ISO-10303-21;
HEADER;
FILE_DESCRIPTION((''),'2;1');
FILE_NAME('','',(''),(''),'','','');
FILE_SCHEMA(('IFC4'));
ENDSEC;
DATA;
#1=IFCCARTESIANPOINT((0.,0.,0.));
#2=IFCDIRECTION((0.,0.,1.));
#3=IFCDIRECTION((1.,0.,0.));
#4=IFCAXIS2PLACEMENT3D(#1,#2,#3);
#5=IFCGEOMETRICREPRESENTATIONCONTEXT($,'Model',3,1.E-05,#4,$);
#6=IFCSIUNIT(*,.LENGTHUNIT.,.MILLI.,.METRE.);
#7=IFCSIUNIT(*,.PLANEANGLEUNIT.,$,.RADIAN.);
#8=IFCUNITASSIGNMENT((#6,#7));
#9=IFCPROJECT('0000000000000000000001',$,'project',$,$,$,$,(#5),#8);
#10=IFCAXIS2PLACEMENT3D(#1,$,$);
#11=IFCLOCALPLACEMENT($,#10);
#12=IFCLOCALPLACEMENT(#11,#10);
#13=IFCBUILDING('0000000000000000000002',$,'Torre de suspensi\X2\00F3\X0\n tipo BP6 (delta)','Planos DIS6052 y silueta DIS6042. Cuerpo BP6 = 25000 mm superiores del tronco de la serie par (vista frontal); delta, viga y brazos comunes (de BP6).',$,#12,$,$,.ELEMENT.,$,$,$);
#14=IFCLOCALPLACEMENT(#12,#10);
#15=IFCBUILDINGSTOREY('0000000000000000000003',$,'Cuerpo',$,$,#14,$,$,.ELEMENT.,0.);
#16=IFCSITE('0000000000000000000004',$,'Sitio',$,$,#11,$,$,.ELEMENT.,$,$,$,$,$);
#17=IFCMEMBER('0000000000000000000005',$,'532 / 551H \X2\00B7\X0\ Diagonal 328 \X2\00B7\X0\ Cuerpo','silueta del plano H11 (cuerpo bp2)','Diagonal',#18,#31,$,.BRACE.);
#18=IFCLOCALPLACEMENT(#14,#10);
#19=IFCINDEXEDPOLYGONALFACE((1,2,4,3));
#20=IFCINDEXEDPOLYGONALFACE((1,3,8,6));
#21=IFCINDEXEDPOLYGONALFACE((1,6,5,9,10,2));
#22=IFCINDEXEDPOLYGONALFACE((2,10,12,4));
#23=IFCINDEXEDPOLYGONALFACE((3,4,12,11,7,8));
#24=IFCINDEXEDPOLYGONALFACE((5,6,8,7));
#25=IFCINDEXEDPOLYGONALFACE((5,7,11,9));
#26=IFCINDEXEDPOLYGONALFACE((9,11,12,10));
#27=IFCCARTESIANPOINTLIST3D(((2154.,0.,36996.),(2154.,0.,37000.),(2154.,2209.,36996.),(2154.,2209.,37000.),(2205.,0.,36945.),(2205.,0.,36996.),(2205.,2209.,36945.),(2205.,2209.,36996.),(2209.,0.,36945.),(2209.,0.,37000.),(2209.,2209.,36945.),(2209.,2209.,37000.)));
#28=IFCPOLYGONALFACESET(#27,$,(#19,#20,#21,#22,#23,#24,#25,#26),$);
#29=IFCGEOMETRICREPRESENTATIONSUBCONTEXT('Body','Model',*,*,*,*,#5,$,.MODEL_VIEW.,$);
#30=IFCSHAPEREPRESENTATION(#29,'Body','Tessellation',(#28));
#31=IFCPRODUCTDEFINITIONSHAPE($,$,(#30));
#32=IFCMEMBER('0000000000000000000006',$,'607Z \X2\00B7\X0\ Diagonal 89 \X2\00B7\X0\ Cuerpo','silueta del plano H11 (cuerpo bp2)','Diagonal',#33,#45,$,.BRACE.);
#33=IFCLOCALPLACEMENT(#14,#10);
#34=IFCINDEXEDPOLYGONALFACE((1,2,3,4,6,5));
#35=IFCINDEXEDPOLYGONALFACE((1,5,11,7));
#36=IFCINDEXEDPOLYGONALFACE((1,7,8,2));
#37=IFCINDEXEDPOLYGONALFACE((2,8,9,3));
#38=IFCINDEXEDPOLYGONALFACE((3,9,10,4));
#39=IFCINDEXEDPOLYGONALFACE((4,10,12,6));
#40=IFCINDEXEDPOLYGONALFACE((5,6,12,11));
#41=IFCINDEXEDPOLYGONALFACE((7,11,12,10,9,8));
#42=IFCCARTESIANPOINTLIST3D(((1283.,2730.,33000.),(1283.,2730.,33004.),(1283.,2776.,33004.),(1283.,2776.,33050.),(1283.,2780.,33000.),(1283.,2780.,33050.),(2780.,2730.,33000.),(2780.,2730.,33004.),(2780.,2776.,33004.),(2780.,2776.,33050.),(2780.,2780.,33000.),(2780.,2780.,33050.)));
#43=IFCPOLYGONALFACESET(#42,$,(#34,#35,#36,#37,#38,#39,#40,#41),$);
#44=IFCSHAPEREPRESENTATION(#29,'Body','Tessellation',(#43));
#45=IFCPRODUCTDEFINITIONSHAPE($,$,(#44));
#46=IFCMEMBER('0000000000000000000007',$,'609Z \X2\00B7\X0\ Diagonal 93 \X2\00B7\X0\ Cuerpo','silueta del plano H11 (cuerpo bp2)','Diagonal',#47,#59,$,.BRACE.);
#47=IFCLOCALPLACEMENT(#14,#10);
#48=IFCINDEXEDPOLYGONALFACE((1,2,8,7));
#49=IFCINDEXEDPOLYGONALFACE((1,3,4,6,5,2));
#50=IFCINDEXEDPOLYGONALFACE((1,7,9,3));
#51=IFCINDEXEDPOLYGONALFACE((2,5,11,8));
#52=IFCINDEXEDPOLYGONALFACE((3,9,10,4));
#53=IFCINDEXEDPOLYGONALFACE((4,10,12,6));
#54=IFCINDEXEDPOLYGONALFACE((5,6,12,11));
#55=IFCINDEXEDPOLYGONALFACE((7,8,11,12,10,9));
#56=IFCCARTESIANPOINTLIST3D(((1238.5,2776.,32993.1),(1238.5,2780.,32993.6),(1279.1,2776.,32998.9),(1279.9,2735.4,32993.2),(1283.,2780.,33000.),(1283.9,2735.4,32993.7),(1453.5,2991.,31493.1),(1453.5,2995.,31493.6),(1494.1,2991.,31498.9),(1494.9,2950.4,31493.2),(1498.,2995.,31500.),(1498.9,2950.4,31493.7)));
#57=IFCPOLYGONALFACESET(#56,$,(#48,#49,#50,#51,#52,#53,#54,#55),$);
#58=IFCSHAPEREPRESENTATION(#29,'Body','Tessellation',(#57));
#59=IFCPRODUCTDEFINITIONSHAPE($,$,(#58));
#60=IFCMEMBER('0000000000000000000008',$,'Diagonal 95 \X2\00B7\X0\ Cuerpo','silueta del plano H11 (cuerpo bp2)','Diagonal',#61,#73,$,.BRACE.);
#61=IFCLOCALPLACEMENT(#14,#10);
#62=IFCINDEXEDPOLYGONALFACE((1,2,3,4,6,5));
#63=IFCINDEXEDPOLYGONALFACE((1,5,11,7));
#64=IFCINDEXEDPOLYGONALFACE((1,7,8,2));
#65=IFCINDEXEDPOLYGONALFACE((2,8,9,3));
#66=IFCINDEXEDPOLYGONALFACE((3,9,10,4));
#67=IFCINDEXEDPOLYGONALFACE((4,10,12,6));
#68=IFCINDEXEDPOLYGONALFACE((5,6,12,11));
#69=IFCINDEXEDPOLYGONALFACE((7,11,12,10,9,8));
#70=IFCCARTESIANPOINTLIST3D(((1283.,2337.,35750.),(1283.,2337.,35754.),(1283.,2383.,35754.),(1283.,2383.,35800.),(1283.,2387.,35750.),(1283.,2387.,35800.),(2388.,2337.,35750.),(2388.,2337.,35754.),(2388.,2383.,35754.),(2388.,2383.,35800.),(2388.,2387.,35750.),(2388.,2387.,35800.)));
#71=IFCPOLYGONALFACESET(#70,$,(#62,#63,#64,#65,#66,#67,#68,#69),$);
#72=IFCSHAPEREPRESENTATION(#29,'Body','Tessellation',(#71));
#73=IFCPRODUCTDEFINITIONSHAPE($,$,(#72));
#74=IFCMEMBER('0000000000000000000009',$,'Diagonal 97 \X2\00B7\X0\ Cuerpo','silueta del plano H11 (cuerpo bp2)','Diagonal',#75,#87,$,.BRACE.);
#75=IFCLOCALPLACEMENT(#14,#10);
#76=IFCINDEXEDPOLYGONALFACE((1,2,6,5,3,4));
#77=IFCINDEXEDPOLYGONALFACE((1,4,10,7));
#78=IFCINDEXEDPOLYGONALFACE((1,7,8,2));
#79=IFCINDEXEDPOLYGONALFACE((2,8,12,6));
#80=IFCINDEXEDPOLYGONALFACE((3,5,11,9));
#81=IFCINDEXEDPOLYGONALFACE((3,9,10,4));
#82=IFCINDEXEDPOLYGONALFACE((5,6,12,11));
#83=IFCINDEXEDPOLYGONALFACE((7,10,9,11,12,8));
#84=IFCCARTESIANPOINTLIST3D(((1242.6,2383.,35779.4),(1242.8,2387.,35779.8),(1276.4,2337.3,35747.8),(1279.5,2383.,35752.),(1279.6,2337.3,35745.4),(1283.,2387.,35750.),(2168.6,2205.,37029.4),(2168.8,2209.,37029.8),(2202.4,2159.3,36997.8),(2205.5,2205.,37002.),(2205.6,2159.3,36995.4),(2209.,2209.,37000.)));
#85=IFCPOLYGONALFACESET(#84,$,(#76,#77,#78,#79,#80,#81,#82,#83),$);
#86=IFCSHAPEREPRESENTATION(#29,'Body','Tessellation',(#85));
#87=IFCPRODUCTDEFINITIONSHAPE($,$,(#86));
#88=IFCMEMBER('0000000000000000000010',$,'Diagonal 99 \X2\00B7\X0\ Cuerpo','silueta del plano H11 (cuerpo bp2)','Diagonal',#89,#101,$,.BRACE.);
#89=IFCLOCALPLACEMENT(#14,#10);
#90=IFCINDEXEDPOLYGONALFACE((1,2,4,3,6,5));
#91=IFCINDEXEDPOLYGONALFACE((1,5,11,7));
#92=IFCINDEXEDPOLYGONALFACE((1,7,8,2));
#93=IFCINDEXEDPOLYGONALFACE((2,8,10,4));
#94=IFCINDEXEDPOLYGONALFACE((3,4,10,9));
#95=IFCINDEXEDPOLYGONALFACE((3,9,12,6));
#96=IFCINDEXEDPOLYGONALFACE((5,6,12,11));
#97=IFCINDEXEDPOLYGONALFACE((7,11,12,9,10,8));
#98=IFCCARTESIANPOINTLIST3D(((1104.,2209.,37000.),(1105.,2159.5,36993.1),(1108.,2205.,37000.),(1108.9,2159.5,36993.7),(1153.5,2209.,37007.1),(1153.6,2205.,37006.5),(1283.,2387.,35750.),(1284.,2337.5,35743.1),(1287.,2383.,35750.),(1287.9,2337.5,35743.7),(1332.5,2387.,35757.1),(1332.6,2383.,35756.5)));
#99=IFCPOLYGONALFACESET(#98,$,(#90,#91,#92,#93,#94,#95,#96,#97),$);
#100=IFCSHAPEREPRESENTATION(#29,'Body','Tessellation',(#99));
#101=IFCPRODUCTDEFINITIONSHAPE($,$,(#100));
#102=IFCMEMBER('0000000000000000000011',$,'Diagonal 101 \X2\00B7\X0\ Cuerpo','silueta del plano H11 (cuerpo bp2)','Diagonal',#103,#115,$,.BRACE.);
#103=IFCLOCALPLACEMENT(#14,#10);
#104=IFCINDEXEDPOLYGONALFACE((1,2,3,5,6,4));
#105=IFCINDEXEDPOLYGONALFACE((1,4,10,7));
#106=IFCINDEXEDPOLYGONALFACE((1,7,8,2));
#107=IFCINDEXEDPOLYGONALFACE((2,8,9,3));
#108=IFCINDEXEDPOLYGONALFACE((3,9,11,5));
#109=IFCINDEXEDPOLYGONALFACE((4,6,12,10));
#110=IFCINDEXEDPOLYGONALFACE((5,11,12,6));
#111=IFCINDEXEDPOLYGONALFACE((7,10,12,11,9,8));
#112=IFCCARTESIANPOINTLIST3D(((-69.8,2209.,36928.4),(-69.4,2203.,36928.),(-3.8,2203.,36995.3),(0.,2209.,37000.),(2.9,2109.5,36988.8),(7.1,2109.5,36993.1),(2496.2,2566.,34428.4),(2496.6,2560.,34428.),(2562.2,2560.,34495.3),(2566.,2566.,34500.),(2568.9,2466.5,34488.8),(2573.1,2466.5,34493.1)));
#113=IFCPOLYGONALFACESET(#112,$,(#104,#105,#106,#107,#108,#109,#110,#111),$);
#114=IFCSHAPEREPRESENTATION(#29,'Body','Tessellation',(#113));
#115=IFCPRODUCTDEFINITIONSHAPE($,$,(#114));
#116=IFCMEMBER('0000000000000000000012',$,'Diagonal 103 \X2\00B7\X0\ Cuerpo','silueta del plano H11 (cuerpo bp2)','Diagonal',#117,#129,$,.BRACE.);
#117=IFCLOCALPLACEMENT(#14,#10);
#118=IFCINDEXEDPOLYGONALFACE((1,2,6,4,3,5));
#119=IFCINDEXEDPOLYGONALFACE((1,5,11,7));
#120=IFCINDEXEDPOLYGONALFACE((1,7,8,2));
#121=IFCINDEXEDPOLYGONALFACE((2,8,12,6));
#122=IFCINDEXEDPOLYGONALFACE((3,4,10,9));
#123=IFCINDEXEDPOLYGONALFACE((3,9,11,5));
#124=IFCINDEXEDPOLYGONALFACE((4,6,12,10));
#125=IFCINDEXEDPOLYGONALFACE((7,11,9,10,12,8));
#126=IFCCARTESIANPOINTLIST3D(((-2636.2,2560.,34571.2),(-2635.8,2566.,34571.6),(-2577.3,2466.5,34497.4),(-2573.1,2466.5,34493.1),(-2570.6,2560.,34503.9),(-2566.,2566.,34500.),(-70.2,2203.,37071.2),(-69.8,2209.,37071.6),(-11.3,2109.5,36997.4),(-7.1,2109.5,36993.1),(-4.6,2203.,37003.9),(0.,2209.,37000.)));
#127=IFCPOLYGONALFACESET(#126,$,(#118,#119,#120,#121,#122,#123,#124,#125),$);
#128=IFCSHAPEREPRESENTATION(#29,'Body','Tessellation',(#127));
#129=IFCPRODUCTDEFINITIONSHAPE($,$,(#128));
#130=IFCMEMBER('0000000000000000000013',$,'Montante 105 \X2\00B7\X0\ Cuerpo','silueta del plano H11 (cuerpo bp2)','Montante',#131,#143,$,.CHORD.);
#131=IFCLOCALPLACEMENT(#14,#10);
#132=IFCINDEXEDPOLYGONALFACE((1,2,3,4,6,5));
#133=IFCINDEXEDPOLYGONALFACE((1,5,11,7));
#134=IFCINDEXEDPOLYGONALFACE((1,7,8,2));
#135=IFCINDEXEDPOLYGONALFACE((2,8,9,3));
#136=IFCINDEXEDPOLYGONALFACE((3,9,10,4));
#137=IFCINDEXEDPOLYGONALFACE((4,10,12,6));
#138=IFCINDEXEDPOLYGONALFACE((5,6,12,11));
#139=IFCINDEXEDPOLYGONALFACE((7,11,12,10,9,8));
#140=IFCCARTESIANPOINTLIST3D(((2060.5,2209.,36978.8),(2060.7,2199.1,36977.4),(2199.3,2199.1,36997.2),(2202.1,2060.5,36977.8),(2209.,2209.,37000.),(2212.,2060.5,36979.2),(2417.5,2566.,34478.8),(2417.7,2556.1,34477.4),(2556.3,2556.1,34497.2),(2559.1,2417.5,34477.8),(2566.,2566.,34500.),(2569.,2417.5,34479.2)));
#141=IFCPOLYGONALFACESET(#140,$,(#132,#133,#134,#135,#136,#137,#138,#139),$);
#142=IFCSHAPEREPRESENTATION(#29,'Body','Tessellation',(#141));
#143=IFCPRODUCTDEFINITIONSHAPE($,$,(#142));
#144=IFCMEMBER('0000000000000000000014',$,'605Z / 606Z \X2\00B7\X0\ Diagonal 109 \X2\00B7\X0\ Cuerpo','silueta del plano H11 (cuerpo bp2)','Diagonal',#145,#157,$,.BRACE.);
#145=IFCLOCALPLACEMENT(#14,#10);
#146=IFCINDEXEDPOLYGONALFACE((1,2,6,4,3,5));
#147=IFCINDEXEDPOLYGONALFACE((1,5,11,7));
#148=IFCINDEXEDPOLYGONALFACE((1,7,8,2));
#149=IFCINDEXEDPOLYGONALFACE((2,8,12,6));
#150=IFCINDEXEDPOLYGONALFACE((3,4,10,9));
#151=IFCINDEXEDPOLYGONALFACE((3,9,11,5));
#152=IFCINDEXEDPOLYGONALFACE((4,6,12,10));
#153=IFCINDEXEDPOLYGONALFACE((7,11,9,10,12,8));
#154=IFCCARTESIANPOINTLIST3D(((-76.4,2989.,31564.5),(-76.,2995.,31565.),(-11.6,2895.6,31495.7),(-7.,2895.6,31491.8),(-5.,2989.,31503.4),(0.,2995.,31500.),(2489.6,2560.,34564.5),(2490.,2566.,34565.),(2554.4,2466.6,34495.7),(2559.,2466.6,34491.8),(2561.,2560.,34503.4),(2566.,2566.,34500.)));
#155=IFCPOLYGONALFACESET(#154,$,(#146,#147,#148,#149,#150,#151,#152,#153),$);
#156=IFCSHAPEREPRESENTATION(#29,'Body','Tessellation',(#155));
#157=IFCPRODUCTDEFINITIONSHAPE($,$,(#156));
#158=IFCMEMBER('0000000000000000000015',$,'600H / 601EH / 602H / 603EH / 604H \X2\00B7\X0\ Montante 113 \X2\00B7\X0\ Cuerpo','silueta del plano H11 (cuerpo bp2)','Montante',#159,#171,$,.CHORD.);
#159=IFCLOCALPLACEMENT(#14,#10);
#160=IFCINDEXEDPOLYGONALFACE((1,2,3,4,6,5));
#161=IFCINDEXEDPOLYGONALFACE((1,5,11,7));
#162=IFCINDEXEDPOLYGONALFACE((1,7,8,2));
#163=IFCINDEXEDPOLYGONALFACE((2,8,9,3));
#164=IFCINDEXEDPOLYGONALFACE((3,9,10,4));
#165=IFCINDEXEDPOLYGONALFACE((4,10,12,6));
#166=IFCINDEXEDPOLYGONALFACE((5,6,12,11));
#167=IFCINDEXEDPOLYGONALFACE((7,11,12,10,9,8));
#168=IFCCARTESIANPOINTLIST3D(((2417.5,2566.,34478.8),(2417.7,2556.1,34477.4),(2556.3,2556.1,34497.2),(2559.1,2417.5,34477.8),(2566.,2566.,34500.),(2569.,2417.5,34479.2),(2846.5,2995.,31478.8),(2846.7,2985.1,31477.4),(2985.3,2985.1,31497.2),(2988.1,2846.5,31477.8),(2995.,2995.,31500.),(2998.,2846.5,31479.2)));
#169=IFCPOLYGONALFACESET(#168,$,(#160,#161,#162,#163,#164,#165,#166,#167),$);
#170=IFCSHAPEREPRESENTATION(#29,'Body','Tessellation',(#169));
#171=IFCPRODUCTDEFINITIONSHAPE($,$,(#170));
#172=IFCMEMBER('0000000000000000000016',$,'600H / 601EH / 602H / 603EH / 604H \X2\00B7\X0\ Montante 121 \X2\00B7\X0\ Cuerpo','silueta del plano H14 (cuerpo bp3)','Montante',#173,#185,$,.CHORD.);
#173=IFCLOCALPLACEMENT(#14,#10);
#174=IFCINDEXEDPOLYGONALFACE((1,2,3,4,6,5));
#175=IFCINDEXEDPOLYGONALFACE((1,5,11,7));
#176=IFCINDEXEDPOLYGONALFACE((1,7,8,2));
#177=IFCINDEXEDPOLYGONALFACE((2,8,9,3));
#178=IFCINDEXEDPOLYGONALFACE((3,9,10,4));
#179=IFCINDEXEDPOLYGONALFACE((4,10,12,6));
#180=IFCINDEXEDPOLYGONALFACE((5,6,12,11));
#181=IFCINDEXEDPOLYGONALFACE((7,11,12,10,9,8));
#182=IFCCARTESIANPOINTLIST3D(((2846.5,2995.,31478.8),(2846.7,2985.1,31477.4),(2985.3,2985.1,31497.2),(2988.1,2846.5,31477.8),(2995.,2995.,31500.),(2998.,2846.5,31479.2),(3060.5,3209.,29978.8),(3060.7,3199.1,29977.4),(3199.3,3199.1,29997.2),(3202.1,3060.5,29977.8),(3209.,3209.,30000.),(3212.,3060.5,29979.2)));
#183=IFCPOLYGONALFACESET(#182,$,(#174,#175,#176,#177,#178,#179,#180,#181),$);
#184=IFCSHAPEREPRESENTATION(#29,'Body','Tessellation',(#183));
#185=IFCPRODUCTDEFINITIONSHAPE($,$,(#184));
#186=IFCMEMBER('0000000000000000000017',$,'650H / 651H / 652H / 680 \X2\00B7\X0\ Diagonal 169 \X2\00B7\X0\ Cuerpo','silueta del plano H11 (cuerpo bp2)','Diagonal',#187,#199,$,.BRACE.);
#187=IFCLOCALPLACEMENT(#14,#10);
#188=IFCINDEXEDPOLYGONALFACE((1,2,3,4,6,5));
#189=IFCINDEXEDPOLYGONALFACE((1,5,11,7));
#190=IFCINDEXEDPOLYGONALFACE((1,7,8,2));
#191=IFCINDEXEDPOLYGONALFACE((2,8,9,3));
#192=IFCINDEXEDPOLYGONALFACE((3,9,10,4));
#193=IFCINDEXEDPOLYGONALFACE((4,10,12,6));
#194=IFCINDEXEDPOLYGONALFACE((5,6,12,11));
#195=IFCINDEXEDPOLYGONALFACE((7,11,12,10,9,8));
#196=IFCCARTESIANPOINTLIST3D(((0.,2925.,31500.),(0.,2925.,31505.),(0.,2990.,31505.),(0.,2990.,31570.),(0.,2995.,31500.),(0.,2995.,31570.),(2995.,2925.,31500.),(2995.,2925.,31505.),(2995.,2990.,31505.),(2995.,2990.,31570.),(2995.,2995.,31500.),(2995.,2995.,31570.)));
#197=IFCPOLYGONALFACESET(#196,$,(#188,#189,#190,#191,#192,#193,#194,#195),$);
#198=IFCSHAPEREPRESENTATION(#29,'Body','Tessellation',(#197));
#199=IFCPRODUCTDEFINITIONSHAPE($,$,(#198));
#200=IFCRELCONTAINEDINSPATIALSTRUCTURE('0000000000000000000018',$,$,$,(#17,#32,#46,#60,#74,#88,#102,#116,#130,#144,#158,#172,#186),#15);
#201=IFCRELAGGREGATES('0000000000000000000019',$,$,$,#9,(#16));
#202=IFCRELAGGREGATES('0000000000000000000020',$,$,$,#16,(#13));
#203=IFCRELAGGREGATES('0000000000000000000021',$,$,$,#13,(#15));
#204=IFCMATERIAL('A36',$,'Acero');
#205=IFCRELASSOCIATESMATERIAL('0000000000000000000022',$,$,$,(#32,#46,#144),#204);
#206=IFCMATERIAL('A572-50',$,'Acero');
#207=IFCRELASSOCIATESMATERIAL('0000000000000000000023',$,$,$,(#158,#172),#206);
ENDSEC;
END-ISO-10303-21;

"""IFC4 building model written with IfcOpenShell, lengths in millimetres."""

from ifc_helpers import new_model, si_unit, frame, frame_2d, origin, origin_with_axes, place, context, subcontext, project, spatial, l_section, extrude, material, element, save


model = new_model("IFC4")

# Units and contexts
model_context = context("Model", 3, precision=1e-05, world=origin_with_axes())
body_context = subcontext(model_context, "Body", "Model", "MODEL_VIEW")
ifc_project = project(units=[si_unit("LENGTHUNIT", "METRE", prefix="MILLI"), si_unit("PLANEANGLEUNIT", "RADIAN")], contexts=[model_context])

# Site, building, storey
site_placement = place(None, origin())
site = spatial("IfcSite", under=ifc_project, at=site_placement, Name="Sitio", CompositionType="ELEMENT")
building_placement = place(site_placement, origin())
building = spatial("IfcBuilding", under=site, at=building_placement, Name="Torre de suspensión tipo BP6 (delta)", Description="Planos DIS6052 y silueta DIS6042. Cuerpo BP6 = 25000 mm superiores del tronco de la serie par (vista frontal); delta, viga y brazos comunes (de BP6).", CompositionType="ELEMENT")
storey_placement = place(building_placement, origin())
storey = spatial("IfcBuildingStorey", under=building, at=storey_placement, Name="Cuerpo", CompositionType="ELEMENT", Elevation=0.0)

# Members
member_1_placement = place(storey_placement, frame((2209.0, 2209.0, 37000.0), z_axis=(0.0, -1.0, 0.0), x_axis=(-1.0, 0.0, 0.0)))
element("IfcMember", 1, at=member_1_placement, inside=storey, Name="532 / 551H · Diagonal 328 · Cuerpo", Description="silueta del plano H11 (cuerpo bp2)", ObjectType="Diagonal", PredefinedType="BRACE", context=body_context, shape_type="SweptSolid", body=[
    extrude(l_section(Depth=55.0, Width=55.0, Thickness=4.0, at=frame_2d((27.5, 27.5))), None, (0.0, 0.0, 1.0), 2209.0),
])
ifc_material_1 = material(Name="A36", Category="Acero")
member_2_placement = place(storey_placement, frame((2780.0, 2780.0, 33000.0), z_axis=(-1.0, 0.0, 0.0), x_axis=(0.0, -1.0, 0.0)))
element("IfcMember", 2, at=member_2_placement, inside=storey, material=ifc_material_1, Name="607Z · Diagonal 89 · Cuerpo", Description="silueta del plano H11 (cuerpo bp2)", ObjectType="Diagonal", PredefinedType="BRACE", context=body_context, shape_type="SweptSolid", body=[
    extrude(l_section(Depth=50.0, Width=50.0, Thickness=4.0, at=frame_2d((25.0, 25.0))), None, (0.0, 0.0, 1.0), 1497.0),
])
member_3_placement = place(storey_placement, frame((1283.0, 2780.0, 33000.0), z_axis=(0.140476, 0.140476, -0.980068), x_axis=(0.019931, -0.990084, -0.139055)))
element("IfcMember", 3, at=member_3_placement, inside=storey, material=ifc_material_1, Name="609Z · Diagonal 93 · Cuerpo", Description="silueta del plano H11 (cuerpo bp2)", ObjectType="Diagonal", PredefinedType="BRACE", context=body_context, shape_type="SweptSolid", body=[
    extrude(l_section(Depth=45.0, Width=45.0, Thickness=4.0, at=frame_2d((22.5, 22.5))), None, (0.0, 0.0, 1.0), 1530.5),
])
member_4_placement = place(storey_placement, frame((2388.0, 2387.0, 35750.0), z_axis=(-1.0, 0.0, 0.0), x_axis=(0.0, -1.0, 0.0)))
element("IfcMember", 4, at=member_4_placement, inside=storey, Name="Diagonal 95 · Cuerpo", Description="silueta del plano H11 (cuerpo bp2)", ObjectType="Diagonal", PredefinedType="BRACE", context=body_context, shape_type="SweptSolid", body=[
    extrude(l_section(Depth=50.0, Width=50.0, Thickness=4.0, at=frame_2d((25.0, 25.0))), None, (0.0, 0.0, 1.0), 1105.0),
])
member_5_placement = place(storey_placement, frame((2209.0, 2209.0, 37000.0), z_axis=(-0.591399, 0.113682, -0.798325), x_axis=(-0.06767, -0.993517, -0.091347)))
element("IfcMember", 5, at=member_5_placement, inside=storey, Name="Diagonal 97 · Cuerpo", Description="silueta del plano H11 (cuerpo bp2)", ObjectType="Diagonal", PredefinedType="BRACE", context=body_context, shape_type="SweptSolid", body=[
    extrude(l_section(Depth=50.0, Width=50.0, Thickness=4.0, at=frame_2d((25.0, 25.0))), None, (0.0, 0.0, 1.0), 1565.8),
])
member_6_placement = place(storey_placement, frame((1283.0, 2387.0, 35750.0), z_axis=(-0.140366, -0.139582, 0.980211), x_axis=(0.019786, -0.990211, -0.138173)))
element("IfcMember", 6, at=member_6_placement, inside=storey, Name="Diagonal 99 · Cuerpo", Description="silueta del plano H11 (cuerpo bp2)", ObjectType="Diagonal", PredefinedType="BRACE", context=body_context, shape_type="SweptSolid", body=[
    extrude(l_section(Depth=50.0, Width=50.0, Thickness=4.0, at=frame_2d((25.0, 25.0))), None, (0.0, 0.0, 1.0), 1275.2),
])
for number, where, z_axis, x_axis, name in (
    (7, (0.0, 2209.0, 37000.0), (0.712728, 0.09916, -0.694396), (0.071024, -0.995072, -0.069197), "Diagonal 101 · Cuerpo"),
    (8, (0.0, 2209.0, 37000.0), (-0.712728, 0.09916, -0.694396), (-0.071024, -0.995072, -0.069197), "Diagonal 103 · Cuerpo"),
):
    element("IfcMember", number, at=place(storey_placement, frame(where, z_axis=z_axis, x_axis=x_axis)), inside=storey, Name=name, Description="silueta del plano H11 (cuerpo bp2)", ObjectType="Diagonal", PredefinedType="BRACE", context=body_context, shape_type="SweptSolid", body=[
        extrude(l_section(Depth=100.0, Width=100.0, Thickness=6.0, at=frame_2d((50.0, 50.0))), None, (0.0, 0.0, 1.0), 3600.3),
    ])
member_7_placement = place(storey_placement, frame((2209.0, 2209.0, 37000.0), z_axis=(0.139974, 0.139974, -0.980211), x_axis=(0.019788, -0.990155, -0.138568)))
element("IfcMember", 9, at=member_7_placement, inside=storey, Name="Montante 105 · Cuerpo", Description="silueta del plano H11 (cuerpo bp2)", ObjectType="Montante", PredefinedType="CHORD", context=body_context, shape_type="SweptSolid", body=[
    extrude(l_section(Depth=150.0, Width=150.0, Thickness=10.0, at=frame_2d((75.0, 75.0))), None, (0.0, 0.0, 1.0), 2550.5),
])
member_8_placement = place(storey_placement, frame((2566.0, 2566.0, 34500.0), z_axis=(-0.646194, 0.108035, -0.755488), x_axis=(-0.070222, -0.994147, -0.082099)))
element("IfcMember", 10, at=member_8_placement, inside=storey, material=ifc_material_1, Name="605Z / 606Z · Diagonal 109 · Cuerpo", Description="silueta del plano H11 (cuerpo bp2)", ObjectType="Diagonal", PredefinedType="BRACE", context=body_context, shape_type="SweptSolid", body=[
    extrude(l_section(Depth=100.0, Width=100.0, Thickness=6.0, at=frame_2d((50.0, 50.0))), None, (0.0, 0.0, 1.0), 3970.9),
])
ifc_material_2 = material(Name="A572-50", Category="Acero")
member_9_placement = place(storey_placement, frame((2566.0, 2566.0, 34500.0), z_axis=(0.140163, 0.140163, -0.980158), x_axis=(0.019841, -0.990129, -0.138751)))
element("IfcMember", 11, at=member_9_placement, inside=storey, material=ifc_material_2, Name="600H / 601EH / 602H / 603EH / 604H · Montante 113 · Cuerpo", Description="silueta del plano H11 (cuerpo bp2)", ObjectType="Montante", PredefinedType="CHORD", context=body_context, shape_type="SweptSolid", body=[
    extrude(l_section(Depth=150.0, Width=150.0, Thickness=10.0, at=frame_2d((75.0, 75.0))), None, (0.0, 0.0, 1.0), 3060.7),
])
member_10_placement = place(storey_placement, frame((2995.0, 2995.0, 31500.0), z_axis=(0.139849, 0.139849, -0.980247), x_axis=(0.019752, -0.990173, -0.138447)))
element("IfcMember", 12, at=member_10_placement, inside=storey, material=ifc_material_2, Name="600H / 601EH / 602H / 603EH / 604H · Montante 121 · Cuerpo", Description="silueta del plano H14 (cuerpo bp3)", ObjectType="Montante", PredefinedType="CHORD", context=body_context, shape_type="SweptSolid", body=[
    extrude(l_section(Depth=150.0, Width=150.0, Thickness=10.0, at=frame_2d((75.0, 75.0))), None, (0.0, 0.0, 1.0), 1530.2),
])
member_11_placement = place(storey_placement, frame((2995.0, 2995.0, 31500.0), z_axis=(-1.0, 0.0, 0.0), x_axis=(0.0, -1.0, 0.0)))
element("IfcMember", 13, at=member_11_placement, inside=storey, Name="650H / 651H / 652H / 680 · Diagonal 169 · Cuerpo", Description="silueta del plano H11 (cuerpo bp2)", ObjectType="Diagonal", PredefinedType="BRACE", context=body_context, shape_type="SweptSolid", body=[
    extrude(l_section(Depth=70.0, Width=70.0, Thickness=5.0, at=frame_2d((35.0, 35.0))), None, (0.0, 0.0, 1.0), 2995.0),
])

save(model, "model.ifc")
